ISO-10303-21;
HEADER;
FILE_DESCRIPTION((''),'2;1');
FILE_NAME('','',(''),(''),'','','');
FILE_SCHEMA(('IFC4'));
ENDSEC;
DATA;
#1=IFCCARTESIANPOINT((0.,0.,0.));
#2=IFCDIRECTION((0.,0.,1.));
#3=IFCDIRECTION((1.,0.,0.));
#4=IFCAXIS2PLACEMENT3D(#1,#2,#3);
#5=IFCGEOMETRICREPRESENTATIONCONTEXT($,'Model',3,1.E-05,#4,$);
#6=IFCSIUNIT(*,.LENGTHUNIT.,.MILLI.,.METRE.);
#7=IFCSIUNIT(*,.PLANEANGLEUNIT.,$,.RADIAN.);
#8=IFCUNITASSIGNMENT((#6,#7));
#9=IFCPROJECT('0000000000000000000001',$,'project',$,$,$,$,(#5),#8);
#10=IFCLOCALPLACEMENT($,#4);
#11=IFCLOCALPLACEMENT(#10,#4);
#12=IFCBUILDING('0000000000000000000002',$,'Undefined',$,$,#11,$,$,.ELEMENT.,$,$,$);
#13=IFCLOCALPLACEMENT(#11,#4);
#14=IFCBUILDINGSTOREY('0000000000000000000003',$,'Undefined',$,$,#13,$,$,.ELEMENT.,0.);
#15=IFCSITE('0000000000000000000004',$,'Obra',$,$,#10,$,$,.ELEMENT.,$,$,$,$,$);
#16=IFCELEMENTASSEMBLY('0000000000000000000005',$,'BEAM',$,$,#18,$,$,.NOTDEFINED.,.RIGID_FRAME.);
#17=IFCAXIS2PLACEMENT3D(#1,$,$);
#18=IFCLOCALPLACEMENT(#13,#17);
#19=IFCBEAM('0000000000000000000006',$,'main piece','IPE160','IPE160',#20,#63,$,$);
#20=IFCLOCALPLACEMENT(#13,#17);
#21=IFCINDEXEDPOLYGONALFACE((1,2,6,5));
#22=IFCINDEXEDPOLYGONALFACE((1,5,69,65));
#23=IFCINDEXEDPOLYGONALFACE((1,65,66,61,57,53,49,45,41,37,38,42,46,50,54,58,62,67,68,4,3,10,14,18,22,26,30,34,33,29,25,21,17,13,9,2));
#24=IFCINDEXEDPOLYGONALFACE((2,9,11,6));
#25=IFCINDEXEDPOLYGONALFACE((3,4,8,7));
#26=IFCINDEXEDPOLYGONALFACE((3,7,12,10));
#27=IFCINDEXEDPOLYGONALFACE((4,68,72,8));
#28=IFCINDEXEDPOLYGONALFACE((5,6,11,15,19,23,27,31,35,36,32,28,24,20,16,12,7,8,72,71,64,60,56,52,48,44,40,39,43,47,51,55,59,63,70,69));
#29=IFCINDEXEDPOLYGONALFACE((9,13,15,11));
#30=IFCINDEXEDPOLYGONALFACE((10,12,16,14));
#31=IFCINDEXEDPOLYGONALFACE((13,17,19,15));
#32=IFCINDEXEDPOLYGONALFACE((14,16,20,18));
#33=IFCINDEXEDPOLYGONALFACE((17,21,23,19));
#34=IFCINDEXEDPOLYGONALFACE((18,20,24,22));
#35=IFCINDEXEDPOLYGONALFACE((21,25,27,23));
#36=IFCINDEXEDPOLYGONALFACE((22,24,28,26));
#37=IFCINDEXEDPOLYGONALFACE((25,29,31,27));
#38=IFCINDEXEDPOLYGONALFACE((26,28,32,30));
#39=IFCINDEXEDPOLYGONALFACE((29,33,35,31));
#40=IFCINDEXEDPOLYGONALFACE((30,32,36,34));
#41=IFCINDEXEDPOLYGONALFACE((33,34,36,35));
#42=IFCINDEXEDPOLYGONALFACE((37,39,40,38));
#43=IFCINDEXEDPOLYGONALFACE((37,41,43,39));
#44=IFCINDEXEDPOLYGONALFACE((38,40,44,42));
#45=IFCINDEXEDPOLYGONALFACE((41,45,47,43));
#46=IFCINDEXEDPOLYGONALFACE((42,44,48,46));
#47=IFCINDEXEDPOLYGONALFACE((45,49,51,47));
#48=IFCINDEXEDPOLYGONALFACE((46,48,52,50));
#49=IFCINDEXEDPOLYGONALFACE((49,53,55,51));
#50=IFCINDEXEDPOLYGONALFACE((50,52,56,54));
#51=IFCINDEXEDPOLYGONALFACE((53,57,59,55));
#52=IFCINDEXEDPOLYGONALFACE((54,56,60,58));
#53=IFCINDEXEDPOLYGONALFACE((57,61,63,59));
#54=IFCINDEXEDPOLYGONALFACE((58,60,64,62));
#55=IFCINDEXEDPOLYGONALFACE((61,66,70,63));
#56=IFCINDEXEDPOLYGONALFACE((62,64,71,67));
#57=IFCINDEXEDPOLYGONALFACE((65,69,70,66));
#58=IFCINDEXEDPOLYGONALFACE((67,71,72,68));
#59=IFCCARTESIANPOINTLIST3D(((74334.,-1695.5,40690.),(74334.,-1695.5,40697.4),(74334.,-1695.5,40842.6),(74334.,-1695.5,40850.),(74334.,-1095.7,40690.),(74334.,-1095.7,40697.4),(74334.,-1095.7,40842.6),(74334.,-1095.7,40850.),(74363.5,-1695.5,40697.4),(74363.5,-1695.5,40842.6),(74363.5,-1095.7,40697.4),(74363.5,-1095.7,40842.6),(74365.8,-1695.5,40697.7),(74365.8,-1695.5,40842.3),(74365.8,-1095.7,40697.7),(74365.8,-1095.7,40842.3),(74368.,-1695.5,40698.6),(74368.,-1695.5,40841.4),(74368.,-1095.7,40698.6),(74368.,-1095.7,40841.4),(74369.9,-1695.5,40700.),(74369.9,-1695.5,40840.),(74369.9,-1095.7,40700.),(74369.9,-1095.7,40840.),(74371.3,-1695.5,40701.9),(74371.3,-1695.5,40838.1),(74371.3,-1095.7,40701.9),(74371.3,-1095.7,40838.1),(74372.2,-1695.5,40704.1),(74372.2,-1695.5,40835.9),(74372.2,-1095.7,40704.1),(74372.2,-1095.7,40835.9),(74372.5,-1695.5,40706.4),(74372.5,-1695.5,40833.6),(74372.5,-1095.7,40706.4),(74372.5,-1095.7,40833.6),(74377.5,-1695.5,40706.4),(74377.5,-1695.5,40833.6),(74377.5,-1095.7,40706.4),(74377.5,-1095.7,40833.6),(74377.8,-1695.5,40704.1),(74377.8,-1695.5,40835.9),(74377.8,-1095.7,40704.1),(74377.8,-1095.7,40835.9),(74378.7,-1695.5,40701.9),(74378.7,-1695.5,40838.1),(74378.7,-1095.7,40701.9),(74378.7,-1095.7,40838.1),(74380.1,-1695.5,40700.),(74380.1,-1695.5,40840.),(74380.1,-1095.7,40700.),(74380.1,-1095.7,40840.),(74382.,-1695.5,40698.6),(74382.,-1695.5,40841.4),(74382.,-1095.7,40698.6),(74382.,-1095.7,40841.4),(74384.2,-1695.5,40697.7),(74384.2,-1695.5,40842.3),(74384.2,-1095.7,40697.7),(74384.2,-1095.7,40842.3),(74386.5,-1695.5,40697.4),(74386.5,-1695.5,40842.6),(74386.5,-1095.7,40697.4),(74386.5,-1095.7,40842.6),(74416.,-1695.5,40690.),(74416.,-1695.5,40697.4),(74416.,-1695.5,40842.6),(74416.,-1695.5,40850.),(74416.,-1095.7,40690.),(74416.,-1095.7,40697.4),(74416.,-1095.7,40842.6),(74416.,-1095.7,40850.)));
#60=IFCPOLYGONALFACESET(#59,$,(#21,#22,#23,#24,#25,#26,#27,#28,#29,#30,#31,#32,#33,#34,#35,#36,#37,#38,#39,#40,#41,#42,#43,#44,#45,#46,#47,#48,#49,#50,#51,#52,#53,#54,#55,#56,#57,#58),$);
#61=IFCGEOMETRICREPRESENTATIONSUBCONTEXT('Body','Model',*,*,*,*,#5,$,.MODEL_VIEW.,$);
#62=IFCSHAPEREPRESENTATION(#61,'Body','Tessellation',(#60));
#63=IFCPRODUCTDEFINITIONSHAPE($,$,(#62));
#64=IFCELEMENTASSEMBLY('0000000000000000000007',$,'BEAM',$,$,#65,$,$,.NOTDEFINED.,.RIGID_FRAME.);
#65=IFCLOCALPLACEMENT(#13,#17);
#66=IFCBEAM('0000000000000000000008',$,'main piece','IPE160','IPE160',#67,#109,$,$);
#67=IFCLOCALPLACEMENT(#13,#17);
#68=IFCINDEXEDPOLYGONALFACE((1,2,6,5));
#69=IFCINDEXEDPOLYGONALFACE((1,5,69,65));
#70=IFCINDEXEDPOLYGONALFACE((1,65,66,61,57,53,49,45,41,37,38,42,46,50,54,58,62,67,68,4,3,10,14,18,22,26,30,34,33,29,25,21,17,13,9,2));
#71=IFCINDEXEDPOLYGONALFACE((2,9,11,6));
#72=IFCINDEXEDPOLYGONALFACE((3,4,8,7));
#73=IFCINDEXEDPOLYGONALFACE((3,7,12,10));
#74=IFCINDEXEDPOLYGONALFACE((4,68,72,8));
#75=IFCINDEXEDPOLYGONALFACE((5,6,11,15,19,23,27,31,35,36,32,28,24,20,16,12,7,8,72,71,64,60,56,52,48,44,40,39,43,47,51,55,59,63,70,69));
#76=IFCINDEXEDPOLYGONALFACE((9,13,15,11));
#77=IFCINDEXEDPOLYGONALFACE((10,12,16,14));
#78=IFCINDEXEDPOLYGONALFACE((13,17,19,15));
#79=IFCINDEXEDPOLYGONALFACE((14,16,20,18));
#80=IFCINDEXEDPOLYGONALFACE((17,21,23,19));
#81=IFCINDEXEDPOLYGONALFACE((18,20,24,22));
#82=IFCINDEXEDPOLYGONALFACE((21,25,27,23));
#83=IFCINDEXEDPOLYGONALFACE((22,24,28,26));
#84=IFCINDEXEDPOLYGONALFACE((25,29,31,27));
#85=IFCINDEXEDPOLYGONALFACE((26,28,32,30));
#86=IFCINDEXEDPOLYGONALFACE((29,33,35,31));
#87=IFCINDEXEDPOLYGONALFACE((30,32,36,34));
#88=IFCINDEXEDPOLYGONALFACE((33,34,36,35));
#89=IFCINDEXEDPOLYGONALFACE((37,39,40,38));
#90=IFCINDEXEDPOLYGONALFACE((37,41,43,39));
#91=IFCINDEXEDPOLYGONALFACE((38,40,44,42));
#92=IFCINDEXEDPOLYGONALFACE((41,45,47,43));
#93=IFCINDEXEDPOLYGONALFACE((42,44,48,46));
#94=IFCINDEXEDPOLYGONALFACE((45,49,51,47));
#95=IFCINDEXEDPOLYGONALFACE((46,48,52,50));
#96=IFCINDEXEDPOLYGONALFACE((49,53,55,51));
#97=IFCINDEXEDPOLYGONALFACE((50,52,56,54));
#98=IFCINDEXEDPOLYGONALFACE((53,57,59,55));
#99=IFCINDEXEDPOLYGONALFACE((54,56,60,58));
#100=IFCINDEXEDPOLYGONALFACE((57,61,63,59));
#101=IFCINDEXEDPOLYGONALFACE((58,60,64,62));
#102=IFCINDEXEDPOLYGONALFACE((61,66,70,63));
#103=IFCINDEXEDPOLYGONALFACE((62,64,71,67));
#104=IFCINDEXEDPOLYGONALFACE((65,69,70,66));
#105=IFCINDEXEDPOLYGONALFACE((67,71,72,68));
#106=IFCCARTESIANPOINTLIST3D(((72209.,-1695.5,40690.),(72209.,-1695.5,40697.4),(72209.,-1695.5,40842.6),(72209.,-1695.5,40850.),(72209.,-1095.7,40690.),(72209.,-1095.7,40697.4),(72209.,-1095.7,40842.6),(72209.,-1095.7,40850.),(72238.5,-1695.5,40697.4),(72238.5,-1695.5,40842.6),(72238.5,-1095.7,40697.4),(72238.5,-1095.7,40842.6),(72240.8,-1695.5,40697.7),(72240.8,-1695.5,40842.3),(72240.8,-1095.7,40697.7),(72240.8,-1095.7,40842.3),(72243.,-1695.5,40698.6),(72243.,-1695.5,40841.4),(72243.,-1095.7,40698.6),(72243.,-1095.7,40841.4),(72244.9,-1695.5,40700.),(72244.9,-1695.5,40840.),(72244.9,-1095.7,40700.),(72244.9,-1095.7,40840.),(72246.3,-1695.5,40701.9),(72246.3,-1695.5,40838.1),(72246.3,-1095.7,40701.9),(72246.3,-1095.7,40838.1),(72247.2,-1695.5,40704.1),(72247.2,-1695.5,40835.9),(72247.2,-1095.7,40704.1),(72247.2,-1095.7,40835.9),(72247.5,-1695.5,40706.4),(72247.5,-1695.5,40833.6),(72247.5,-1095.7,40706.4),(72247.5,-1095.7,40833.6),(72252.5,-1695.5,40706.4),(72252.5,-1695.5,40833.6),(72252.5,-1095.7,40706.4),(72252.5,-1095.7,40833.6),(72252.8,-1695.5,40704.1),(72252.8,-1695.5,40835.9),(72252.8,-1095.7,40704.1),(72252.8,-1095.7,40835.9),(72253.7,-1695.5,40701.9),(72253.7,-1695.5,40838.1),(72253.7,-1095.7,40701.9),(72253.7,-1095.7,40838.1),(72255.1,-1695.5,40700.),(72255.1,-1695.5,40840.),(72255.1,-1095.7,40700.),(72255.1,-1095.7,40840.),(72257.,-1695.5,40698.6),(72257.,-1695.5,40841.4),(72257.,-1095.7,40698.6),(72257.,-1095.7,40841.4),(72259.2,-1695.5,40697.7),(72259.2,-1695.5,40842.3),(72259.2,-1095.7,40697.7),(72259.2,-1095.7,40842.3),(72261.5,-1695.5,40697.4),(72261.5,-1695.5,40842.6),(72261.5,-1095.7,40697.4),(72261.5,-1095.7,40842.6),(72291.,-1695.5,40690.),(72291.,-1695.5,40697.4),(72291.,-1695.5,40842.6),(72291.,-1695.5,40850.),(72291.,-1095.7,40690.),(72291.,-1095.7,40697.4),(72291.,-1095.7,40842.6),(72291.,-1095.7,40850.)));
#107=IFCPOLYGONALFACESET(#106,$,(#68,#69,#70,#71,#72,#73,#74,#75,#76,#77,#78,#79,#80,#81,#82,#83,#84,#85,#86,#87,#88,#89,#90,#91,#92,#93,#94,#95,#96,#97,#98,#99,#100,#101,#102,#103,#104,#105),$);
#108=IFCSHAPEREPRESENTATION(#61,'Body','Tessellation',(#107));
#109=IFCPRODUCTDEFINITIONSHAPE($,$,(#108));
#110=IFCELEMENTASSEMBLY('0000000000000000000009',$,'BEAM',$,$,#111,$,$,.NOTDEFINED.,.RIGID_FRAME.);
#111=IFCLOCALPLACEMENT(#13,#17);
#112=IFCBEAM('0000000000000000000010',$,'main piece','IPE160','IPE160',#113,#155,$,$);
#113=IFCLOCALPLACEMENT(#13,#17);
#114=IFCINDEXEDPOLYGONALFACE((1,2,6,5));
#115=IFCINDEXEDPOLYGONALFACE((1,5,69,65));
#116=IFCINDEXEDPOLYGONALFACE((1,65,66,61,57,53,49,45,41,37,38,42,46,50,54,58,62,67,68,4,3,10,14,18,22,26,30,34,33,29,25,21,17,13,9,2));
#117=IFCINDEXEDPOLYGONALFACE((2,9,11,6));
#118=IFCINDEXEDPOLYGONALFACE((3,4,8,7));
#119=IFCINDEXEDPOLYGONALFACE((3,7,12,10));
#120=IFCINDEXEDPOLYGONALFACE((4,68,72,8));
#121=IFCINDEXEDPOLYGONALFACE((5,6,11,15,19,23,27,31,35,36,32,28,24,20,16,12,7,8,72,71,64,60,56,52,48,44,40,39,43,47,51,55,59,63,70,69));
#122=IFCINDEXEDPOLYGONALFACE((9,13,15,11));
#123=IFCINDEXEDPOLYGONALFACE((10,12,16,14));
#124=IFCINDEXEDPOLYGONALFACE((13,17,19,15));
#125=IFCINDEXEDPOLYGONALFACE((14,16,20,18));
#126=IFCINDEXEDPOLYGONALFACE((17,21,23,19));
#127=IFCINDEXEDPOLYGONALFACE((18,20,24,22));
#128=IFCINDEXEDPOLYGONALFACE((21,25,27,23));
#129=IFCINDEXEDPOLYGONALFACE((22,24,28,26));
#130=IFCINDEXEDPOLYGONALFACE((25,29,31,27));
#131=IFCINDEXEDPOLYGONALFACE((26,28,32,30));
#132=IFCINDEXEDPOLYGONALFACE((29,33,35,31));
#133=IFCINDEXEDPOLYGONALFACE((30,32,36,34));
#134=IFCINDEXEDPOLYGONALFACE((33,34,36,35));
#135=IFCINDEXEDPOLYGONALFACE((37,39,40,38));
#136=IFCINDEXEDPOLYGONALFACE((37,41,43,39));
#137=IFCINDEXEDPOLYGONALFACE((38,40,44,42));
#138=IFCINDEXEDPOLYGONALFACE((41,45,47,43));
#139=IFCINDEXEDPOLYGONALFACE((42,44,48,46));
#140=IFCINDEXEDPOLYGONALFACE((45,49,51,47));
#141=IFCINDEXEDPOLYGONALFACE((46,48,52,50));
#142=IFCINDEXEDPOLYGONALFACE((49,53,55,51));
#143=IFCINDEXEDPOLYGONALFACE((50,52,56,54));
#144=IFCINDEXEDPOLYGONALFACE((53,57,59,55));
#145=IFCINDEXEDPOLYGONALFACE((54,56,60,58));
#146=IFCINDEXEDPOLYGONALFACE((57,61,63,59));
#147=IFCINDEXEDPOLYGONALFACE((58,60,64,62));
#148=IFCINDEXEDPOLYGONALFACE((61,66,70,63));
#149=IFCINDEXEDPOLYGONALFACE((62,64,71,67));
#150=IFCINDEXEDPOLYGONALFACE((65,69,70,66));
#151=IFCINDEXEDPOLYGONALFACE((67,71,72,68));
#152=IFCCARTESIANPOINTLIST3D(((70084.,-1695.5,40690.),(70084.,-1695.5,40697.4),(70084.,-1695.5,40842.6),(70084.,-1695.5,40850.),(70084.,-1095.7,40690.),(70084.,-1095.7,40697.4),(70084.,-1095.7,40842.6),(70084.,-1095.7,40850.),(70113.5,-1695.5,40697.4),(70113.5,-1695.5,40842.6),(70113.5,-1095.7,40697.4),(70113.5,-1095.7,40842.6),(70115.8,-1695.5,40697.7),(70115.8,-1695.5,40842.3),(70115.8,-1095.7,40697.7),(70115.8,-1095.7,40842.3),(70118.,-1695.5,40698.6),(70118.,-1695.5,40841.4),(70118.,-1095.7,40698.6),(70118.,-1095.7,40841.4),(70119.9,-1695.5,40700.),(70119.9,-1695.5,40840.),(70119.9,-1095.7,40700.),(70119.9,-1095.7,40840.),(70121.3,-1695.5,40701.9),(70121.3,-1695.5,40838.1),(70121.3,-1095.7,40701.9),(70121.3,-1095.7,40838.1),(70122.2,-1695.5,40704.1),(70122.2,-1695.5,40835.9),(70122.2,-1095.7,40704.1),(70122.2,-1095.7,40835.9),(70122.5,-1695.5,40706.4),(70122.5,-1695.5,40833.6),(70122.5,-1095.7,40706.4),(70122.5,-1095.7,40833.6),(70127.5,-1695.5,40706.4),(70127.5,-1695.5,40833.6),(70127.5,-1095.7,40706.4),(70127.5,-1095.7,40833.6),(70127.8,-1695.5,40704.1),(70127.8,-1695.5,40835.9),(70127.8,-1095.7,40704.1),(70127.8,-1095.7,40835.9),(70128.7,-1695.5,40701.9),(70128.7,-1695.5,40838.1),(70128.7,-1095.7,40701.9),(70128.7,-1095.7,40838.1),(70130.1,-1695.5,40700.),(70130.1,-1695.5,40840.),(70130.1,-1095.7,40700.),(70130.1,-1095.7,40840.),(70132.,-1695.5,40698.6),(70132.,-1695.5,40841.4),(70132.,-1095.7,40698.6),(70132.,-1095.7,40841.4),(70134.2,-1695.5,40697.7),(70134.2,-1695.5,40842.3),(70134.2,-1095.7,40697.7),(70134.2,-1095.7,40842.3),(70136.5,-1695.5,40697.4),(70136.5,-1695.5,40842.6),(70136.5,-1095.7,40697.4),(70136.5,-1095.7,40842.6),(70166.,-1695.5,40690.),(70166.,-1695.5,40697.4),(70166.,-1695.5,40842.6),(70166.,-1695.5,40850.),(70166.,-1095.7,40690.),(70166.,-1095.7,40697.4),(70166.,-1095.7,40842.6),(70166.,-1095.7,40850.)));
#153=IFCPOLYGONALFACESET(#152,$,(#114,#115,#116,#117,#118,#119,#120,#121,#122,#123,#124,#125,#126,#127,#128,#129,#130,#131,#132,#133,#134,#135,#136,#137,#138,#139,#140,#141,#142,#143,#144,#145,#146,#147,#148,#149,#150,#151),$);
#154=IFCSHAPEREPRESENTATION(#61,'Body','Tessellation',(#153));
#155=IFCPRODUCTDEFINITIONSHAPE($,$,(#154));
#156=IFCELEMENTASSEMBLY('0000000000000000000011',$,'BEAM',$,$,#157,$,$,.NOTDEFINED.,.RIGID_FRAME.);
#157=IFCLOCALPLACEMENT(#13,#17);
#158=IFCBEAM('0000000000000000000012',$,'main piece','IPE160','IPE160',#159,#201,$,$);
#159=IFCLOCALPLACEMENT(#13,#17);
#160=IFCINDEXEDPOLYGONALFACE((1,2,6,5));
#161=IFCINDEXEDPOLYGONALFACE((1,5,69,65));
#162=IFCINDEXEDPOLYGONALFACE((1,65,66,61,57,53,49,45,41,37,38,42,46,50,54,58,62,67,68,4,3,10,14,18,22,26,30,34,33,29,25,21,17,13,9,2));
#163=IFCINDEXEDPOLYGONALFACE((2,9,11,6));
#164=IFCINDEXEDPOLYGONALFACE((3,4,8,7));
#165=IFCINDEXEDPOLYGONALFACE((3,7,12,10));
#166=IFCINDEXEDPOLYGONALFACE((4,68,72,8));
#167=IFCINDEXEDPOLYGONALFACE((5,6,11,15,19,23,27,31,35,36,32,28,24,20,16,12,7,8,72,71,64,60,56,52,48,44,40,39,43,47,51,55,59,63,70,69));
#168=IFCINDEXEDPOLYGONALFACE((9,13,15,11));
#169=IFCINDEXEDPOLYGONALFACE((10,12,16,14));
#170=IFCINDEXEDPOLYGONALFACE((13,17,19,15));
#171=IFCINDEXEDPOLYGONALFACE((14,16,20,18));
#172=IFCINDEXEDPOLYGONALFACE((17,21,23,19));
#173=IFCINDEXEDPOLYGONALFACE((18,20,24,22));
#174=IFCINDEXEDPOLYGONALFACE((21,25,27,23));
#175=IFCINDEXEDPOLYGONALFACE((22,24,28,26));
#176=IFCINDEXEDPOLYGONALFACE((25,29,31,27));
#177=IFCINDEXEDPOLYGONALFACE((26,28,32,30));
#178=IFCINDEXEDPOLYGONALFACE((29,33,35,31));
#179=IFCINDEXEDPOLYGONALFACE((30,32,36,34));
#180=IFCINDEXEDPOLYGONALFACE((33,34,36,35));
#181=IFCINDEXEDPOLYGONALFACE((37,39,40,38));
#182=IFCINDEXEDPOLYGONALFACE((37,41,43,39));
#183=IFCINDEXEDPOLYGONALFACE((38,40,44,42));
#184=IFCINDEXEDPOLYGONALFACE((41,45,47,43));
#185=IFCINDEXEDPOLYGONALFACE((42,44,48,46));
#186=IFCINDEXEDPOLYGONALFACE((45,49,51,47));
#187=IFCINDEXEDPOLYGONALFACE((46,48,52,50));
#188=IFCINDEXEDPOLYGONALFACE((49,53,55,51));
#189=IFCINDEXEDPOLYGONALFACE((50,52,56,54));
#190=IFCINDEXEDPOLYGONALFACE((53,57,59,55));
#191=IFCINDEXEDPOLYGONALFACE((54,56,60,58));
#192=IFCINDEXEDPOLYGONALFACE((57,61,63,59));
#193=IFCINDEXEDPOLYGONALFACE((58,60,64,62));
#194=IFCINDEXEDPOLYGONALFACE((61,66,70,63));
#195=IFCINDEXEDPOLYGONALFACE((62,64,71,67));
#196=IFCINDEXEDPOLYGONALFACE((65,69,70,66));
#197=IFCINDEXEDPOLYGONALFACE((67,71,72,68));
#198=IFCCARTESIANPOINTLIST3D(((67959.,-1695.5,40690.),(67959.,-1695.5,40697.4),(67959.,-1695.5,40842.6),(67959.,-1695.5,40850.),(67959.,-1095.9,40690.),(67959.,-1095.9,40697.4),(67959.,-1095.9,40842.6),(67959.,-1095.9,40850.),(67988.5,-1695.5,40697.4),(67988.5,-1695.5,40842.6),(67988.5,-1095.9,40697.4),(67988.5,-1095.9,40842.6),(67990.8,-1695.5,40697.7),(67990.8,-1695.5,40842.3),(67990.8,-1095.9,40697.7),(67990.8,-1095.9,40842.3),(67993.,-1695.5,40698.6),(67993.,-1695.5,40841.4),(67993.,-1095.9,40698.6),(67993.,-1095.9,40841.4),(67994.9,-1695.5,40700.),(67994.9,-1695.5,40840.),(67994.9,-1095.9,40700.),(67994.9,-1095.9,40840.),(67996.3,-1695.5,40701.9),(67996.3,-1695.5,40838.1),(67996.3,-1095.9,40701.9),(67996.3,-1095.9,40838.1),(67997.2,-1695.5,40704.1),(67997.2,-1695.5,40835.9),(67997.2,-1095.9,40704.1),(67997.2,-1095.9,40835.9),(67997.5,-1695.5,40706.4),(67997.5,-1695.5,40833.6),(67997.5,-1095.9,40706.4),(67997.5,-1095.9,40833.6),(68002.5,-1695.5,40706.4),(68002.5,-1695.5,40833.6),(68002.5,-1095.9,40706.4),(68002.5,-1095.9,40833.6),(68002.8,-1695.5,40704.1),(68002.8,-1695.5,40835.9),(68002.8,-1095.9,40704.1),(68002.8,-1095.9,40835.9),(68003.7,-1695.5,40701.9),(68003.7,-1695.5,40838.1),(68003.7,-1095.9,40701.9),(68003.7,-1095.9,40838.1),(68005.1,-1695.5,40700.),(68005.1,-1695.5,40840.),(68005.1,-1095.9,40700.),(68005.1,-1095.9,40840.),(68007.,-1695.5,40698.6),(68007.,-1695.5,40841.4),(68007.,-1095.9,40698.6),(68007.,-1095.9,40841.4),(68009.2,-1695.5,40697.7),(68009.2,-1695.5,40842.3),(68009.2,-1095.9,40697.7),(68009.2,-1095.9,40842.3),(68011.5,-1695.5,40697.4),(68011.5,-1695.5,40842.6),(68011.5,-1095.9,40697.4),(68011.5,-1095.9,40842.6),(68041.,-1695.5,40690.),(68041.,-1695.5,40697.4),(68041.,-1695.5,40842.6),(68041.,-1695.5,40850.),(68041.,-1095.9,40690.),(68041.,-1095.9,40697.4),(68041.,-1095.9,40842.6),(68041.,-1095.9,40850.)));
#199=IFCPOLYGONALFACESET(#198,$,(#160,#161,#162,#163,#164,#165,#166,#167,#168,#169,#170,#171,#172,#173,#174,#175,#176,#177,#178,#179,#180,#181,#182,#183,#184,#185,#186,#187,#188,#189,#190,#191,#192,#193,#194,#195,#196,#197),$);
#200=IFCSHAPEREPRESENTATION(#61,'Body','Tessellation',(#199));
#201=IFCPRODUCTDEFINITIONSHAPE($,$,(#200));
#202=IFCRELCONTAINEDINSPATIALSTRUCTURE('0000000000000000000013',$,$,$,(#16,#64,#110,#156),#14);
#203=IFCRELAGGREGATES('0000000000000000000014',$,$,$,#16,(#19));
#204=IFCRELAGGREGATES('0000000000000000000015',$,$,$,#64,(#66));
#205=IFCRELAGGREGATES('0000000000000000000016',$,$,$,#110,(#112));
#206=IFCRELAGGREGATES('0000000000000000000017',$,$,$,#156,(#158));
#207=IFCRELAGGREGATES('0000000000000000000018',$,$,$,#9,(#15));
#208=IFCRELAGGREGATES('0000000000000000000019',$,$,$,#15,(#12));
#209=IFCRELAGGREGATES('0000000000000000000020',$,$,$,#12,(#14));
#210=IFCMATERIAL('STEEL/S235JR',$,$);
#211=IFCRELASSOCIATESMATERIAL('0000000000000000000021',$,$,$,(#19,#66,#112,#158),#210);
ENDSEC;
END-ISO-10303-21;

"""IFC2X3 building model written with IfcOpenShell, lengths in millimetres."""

from ifc_helpers import new_model, si_unit, frame, origin_with_axes, origin_2d_with_axis, place, context, subcontext, project, spatial, i_section, extrude, material, element, aggregate, save


model = new_model("IFC2X3")

# Units and contexts
model_context = context("Model", 3, precision=1e-05, world=origin_with_axes())
body_context = subcontext(model_context, "Body", "Model", "MODEL_VIEW")
ifc_project = project(units=[si_unit("LENGTHUNIT", "METRE", prefix="MILLI"), si_unit("PLANEANGLEUNIT", "RADIAN")], contexts=[model_context])

# Site, building, storey
site_placement = place(None, origin_with_axes())
site = spatial("IfcSite", under=ifc_project, at=site_placement, Name="Obra", CompositionType="ELEMENT")
building_placement = place(site_placement, origin_with_axes())
building = spatial("IfcBuilding", under=site, at=building_placement, Name="Undefined", CompositionType="ELEMENT")
storey_placement = place(building_placement, origin_with_axes())
storey = spatial("IfcBuildingStorey", under=building, at=storey_placement, Name="Undefined", CompositionType="ELEMENT", Elevation=0.0)

# Element assemblies, beams
ifc_material_1 = material(Name="STEEL/S235JR")
assembly_1_placement = place(storey_placement, origin_with_axes())
assembly_1 = element("IfcElementAssembly", 1, at=assembly_1_placement, inside=storey, Name="BEAM", AssemblyPlace="NOTDEFINED", PredefinedType="RIGID_FRAME")
beam_1_placement = place(assembly_1_placement, frame((74375.0, -1095.7, 40770.0), z_axis=(0.0, 0.0, 1.0), x_axis=(0.0, -1.0, 0.0)))
beam_1 = element("IfcBeam", 2, at=beam_1_placement, material=ifc_material_1, Name="main piece", Description="IPE160", ObjectType="IPE160", context=body_context, shape_type="SweptSolid", body=[
    extrude(i_section(OverallWidth=82.0, OverallDepth=160.0, WebThickness=5.0, FlangeThickness=7.4, FilletRadius=9.0, at=origin_2d_with_axis()), frame((599.8, 0.0, 0.0), z_axis=(-1.0, 0.0, 0.0), x_axis=(0.0, -1.0, 0.0)), (0.0, 0.0, 1.0), 599.8),
])
aggregate(assembly_1, [beam_1])
assembly_2_placement = place(storey_placement, origin_with_axes())
assembly_2 = element("IfcElementAssembly", 3, at=assembly_2_placement, inside=storey, Name="BEAM", AssemblyPlace="NOTDEFINED", PredefinedType="RIGID_FRAME")
beam_2_placement = place(assembly_2_placement, frame((72250.0, -1095.7, 40770.0), z_axis=(0.0, 0.0, 1.0), x_axis=(0.0, -1.0, 0.0)))
beam_2 = element("IfcBeam", 4, at=beam_2_placement, material=ifc_material_1, Name="main piece", Description="IPE160", ObjectType="IPE160", context=body_context, shape_type="SweptSolid", body=[
    extrude(i_section(OverallWidth=82.0, OverallDepth=160.0, WebThickness=5.0, FlangeThickness=7.4, FilletRadius=9.0, at=origin_2d_with_axis()), frame((599.8, 0.0, 0.0), z_axis=(-1.0, 0.0, 0.0), x_axis=(0.0, -1.0, 0.0)), (0.0, 0.0, 1.0), 599.8),
])
aggregate(assembly_2, [beam_2])
assembly_3_placement = place(storey_placement, origin_with_axes())
assembly_3 = element("IfcElementAssembly", 5, at=assembly_3_placement, inside=storey, Name="BEAM", AssemblyPlace="NOTDEFINED", PredefinedType="RIGID_FRAME")
beam_3_placement = place(assembly_3_placement, frame((70125.0, -1695.5, 40770.0), z_axis=(0.0, 0.0, 1.0), x_axis=(0.0, 1.0, 0.0)))
beam_3 = element("IfcBeam", 6, at=beam_3_placement, material=ifc_material_1, Name="main piece", Description="IPE160", ObjectType="IPE160", context=body_context, shape_type="SweptSolid", body=[
    extrude(i_section(OverallWidth=82.0, OverallDepth=160.0, WebThickness=5.0, FlangeThickness=7.4, FilletRadius=9.0, at=origin_2d_with_axis()), frame((599.8, 0.0, 0.0), z_axis=(-1.0, 0.0, 0.0), x_axis=(0.0, -1.0, 0.0)), (0.0, 0.0, 1.0), 599.8),
])
aggregate(assembly_3, [beam_3])
assembly_4_placement = place(storey_placement, origin_with_axes())
assembly_4 = element("IfcElementAssembly", 7, at=assembly_4_placement, inside=storey, Name="BEAM", AssemblyPlace="NOTDEFINED", PredefinedType="RIGID_FRAME")
beam_4_placement = place(assembly_4_placement, frame((68000.0, -1095.9, 40770.0), z_axis=(0.0, 0.0, 1.0), x_axis=(0.0, -1.0, 0.0)))
beam_4 = element("IfcBeam", 8, at=beam_4_placement, material=ifc_material_1, Name="main piece", Description="IPE160", ObjectType="IPE160", context=body_context, shape_type="SweptSolid", body=[
    extrude(i_section(OverallWidth=82.0, OverallDepth=160.0, WebThickness=5.0, FlangeThickness=7.4, FilletRadius=9.0, at=origin_2d_with_axis()), frame((599.6, 0.0, 0.0), z_axis=(-1.0, 0.0, 0.0), x_axis=(0.0, -1.0, 0.0)), (0.0, 0.0, 1.0), 599.6),
])
aggregate(assembly_4, [beam_4])

save(model, "model.ifc")
